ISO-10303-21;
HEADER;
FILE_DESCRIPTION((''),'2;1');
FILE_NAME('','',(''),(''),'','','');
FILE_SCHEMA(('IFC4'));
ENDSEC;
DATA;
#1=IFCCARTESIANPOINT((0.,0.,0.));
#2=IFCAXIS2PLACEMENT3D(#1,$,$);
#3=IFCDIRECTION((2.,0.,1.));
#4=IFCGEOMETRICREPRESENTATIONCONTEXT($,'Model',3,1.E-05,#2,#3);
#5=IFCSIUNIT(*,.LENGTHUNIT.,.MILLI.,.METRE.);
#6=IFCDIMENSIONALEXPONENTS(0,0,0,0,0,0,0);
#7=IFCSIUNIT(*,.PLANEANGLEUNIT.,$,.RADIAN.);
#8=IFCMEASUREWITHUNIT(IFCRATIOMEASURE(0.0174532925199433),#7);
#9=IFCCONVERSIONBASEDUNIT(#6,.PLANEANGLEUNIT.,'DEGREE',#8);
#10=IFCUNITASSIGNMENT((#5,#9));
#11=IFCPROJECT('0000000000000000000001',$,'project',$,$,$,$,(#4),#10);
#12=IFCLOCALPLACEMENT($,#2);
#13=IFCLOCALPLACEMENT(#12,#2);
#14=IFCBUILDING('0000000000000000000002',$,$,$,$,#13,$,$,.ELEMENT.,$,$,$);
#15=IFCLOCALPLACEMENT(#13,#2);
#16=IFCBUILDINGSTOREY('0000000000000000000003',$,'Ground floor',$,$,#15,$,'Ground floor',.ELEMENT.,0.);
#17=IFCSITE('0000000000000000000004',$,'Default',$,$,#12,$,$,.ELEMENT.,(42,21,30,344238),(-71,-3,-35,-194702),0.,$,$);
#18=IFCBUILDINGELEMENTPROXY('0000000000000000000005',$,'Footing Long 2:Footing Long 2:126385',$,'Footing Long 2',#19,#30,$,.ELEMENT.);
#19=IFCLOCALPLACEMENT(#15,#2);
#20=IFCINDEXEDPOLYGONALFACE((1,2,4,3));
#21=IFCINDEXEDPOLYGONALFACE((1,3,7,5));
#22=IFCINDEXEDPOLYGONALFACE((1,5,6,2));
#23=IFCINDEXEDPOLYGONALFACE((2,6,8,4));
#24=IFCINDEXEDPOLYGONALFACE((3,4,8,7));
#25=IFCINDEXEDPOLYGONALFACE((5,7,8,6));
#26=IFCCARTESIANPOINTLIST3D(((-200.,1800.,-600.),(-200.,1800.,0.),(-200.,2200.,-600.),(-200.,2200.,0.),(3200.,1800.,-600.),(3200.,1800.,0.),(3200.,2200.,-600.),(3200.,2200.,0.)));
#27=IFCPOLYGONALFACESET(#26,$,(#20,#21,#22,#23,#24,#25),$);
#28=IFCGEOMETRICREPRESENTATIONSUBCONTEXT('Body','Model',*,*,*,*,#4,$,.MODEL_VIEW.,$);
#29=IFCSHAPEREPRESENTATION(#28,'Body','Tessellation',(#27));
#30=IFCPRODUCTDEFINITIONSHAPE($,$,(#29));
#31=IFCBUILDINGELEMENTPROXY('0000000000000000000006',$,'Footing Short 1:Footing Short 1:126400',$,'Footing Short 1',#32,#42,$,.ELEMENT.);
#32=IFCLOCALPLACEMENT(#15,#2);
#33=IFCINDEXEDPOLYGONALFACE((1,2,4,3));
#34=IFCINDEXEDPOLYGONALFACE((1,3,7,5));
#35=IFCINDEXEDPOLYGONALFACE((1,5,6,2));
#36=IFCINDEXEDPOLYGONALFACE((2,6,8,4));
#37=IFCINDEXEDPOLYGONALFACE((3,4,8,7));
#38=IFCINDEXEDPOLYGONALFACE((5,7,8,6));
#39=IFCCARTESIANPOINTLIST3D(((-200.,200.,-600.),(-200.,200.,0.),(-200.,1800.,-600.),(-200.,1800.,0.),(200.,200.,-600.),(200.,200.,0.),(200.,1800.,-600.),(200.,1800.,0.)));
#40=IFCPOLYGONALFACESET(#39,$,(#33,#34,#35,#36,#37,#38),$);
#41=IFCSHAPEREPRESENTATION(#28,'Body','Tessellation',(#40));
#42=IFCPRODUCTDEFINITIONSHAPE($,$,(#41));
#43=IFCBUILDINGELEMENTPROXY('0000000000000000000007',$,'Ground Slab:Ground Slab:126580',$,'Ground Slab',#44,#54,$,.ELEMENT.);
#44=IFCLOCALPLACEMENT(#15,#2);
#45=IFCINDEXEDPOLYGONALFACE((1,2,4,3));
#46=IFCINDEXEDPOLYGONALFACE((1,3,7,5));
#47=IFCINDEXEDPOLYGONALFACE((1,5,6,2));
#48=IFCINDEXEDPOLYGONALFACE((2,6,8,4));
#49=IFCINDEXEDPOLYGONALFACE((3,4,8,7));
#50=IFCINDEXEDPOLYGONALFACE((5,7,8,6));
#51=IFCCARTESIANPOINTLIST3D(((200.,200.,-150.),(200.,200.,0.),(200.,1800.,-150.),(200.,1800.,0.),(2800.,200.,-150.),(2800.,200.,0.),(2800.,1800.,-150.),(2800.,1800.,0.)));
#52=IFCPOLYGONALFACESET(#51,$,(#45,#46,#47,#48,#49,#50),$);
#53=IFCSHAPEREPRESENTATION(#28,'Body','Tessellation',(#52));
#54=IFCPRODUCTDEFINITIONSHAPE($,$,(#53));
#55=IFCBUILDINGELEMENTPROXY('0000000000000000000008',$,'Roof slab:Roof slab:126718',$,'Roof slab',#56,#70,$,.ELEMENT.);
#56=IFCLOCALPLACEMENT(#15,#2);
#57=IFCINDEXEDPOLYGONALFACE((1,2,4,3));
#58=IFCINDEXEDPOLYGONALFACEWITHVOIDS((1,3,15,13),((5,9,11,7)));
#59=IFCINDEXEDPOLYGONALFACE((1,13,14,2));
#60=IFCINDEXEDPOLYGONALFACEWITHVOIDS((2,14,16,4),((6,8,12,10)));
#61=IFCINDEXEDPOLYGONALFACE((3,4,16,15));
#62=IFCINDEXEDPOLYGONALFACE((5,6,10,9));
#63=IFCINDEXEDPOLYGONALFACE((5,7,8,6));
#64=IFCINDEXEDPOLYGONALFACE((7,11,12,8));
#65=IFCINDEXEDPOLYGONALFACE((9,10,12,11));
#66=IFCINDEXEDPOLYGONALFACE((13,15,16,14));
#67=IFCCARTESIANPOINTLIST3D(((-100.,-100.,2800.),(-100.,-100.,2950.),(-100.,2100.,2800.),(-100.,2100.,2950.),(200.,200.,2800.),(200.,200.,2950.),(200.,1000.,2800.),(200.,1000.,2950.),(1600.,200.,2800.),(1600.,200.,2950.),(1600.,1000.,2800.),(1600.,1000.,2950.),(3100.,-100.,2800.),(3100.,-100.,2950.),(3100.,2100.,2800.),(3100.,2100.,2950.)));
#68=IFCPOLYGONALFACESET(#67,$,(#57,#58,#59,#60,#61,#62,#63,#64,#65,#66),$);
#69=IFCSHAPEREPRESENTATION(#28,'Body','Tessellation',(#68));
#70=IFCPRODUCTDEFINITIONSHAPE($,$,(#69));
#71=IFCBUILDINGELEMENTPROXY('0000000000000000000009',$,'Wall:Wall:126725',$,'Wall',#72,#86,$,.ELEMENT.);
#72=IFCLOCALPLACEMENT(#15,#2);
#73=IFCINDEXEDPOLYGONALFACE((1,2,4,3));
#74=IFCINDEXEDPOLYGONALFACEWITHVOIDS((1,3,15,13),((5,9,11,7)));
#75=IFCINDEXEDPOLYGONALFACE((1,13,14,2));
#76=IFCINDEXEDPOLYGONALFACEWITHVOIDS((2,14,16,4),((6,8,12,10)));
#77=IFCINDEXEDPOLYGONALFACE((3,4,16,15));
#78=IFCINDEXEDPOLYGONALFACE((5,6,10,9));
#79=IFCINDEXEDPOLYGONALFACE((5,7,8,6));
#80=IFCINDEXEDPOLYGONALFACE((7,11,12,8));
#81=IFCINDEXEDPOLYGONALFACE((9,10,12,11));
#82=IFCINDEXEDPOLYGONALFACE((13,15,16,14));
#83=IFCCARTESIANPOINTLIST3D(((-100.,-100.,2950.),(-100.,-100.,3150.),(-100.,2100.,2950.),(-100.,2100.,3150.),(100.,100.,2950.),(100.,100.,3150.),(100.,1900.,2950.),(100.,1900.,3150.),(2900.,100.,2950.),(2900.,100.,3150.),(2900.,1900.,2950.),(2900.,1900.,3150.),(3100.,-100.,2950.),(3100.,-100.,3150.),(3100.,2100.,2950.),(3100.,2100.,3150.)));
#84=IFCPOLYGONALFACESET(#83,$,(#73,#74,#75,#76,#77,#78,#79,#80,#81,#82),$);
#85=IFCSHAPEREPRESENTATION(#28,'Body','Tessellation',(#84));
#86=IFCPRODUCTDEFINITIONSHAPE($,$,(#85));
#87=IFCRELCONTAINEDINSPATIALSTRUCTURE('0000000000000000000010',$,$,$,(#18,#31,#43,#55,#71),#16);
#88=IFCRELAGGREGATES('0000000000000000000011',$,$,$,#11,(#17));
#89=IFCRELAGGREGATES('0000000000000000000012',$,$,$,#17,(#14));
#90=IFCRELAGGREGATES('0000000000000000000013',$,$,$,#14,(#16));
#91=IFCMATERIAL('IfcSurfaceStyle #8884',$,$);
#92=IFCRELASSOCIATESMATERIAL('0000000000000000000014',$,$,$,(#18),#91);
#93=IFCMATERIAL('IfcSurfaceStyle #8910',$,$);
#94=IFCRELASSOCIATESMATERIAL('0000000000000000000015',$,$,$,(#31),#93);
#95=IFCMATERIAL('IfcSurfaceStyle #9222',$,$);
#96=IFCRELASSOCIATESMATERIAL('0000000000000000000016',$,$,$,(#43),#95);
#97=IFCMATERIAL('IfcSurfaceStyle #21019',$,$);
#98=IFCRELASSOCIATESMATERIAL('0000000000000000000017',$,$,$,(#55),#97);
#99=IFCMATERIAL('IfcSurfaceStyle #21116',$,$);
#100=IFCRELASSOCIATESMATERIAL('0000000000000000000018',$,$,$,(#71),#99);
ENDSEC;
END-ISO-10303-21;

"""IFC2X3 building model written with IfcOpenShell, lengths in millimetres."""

from ifc_helpers import new_model, entity, si_unit, converted_unit, direction, frame, origin, origin_2d_with_axis, place, context, subcontext, project, spatial, polyline, rectangle, outline, extrude, source, transform, mapped, material, element, save


model = new_model("IFC2X3")

# Units and contexts
model_context = context("Model", 3, precision=1e-05, world=origin(), true_north=direction((2.0, 0.0, 1.0)))
body_context = subcontext(model_context, "Body", "Model", "MODEL_VIEW")
ifc_project = project(units=[si_unit("LENGTHUNIT", "METRE", prefix="MILLI"), converted_unit("PLANEANGLEUNIT", "DEGREE", entity("IfcRatioMeasure", 0.0174532925199433), si_unit("PLANEANGLEUNIT", "RADIAN"), dimensions=[0, 0, 0, 0, 0, 0, 0])], contexts=[model_context])

# Site, building, storey
site_placement = place(None, origin())
site = spatial("IfcSite", under=ifc_project, at=site_placement, Name="Default", CompositionType="ELEMENT", RefLatitude=(42, 21, 30, 344238), RefLongitude=(-71, -3, -35, -194702), RefElevation=0.0)
building_placement = place(site_placement, origin())
building = spatial("IfcBuilding", under=site, at=building_placement, CompositionType="ELEMENT")
storey_placement = place(building_placement, origin())
storey = spatial("IfcBuildingStorey", under=building, at=storey_placement, Name="Ground floor", LongName="Ground floor", CompositionType="ELEMENT", Elevation=0.0)

# Building element proxies
ifc_material_1 = material(Name="IfcSurfaceStyle #8884")
shared_shape_1 = source(origin(), body_context, "Body", "SweptSolid", [
    extrude(rectangle(XDim=3400.0, YDim=400.0, at=origin_2d_with_axis()), frame((1700.0, 200.0, 0.0), z_axis=(0.0, 0.0, 1.0), x_axis=(-1.0, 0.0, 0.0)), (0.0, 0.0, 1.0), 600.0),
])
proxy_1_placement = place(building_placement, frame((-200.0, 1800.0, -600.0)))
element("IfcBuildingElementProxy", 1, at=proxy_1_placement, inside=storey, material=ifc_material_1, Name="Footing Long 2:Footing Long 2:126385", ObjectType="Footing Long 2", CompositionType="ELEMENT", context=body_context, shape_type="MappedRepresentation", body=[
    mapped(shared_shape_1, transform((0.0, 0.0, 0.0), scale=1.0)),
])
ifc_material_2 = material(Name="IfcSurfaceStyle #8910")
shared_shape_2 = source(origin(), body_context, "Body", "SweptSolid", [
    extrude(rectangle(XDim=1600.0, YDim=400.0, at=origin_2d_with_axis()), frame((200.0, 800.0, 0.0), z_axis=(0.0, 0.0, 1.0), x_axis=(0.0, -1.0, 0.0)), (0.0, 0.0, 1.0), 600.0),
])
proxy_2_placement = place(building_placement, frame((-200.0, 200.0, -600.0)))
element("IfcBuildingElementProxy", 2, at=proxy_2_placement, inside=storey, material=ifc_material_2, Name="Footing Short 1:Footing Short 1:126400", ObjectType="Footing Short 1", CompositionType="ELEMENT", context=body_context, shape_type="MappedRepresentation", body=[
    mapped(shared_shape_2, transform((0.0, 0.0, 0.0), scale=1.0)),
])
ifc_material_3 = material(Name="IfcSurfaceStyle #9222")
shared_shape_3 = source(origin(), body_context, "Body", "SweptSolid", [
    extrude(rectangle(XDim=2600.0, YDim=1600.0, at=origin_2d_with_axis()), frame((1300.0, 800.0, 0.0)), (0.0, 0.0, 1.0), 150.0),
])
proxy_3_placement = place(building_placement, frame((200.0, 200.0, -150.0)))
element("IfcBuildingElementProxy", 3, at=proxy_3_placement, inside=storey, material=ifc_material_3, Name="Ground Slab:Ground Slab:126580", ObjectType="Ground Slab", CompositionType="ELEMENT", context=body_context, shape_type="MappedRepresentation", body=[
    mapped(shared_shape_3, transform((0.0, 0.0, 0.0), scale=1.0)),
])
ifc_material_4 = material(Name="IfcSurfaceStyle #21019")
shared_shape_4 = source(origin(), body_context, "Body", "SweptSolid", [
    extrude(outline(polyline([(-1600.0, -1100.0), (1600.0, -1100.0), (1600.0, 1100.0), (-1600.0, 1100.0), (-1600.0, -1100.0)]), holes=[polyline([(100.0, 0.0), (100.0, -800.0), (-1300.0, -800.0), (-1300.0, 0.0), (100.0, 0.0)])]), frame((1600.0, 1100.0, 0.0)), (0.0, 0.0, 1.0), 150.0),
])
proxy_4_placement = place(building_placement, frame((-100.0, -100.0, 2800.0)))
element("IfcBuildingElementProxy", 4, at=proxy_4_placement, inside=storey, material=ifc_material_4, Name="Roof slab:Roof slab:126718", ObjectType="Roof slab", CompositionType="ELEMENT", context=body_context, shape_type="MappedRepresentation", body=[
    mapped(shared_shape_4, transform((0.0, 0.0, 0.0), scale=1.0)),
])
ifc_material_5 = material(Name="IfcSurfaceStyle #21116")
shared_shape_5 = source(origin(), body_context, "Body", "SweptSolid", [
    extrude(outline(polyline([(-1600.0, -1100.0), (1600.0, -1100.0), (1600.0, 1100.0), (-1600.0, 1100.0), (-1600.0, -1100.0)]), holes=[polyline([(-1400.0, 900.0), (1400.0, 900.0), (1400.0, -900.0), (-1400.0, -900.0), (-1400.0, 900.0)])]), frame((1600.0, 1100.0, 0.0), z_axis=(0.0, 0.0, 1.0), x_axis=(-1.0, 0.0, 0.0)), (0.0, 0.0, 1.0), 200.0),
])
proxy_5_placement = place(building_placement, frame((-100.0, -100.0, 2950.0)))
element("IfcBuildingElementProxy", 5, at=proxy_5_placement, inside=storey, material=ifc_material_5, Name="Wall:Wall:126725", ObjectType="Wall", CompositionType="ELEMENT", context=body_context, shape_type="MappedRepresentation", body=[
    mapped(shared_shape_5, transform((0.0, 0.0, 0.0), scale=1.0)),
])

save(model, "model.ifc")
